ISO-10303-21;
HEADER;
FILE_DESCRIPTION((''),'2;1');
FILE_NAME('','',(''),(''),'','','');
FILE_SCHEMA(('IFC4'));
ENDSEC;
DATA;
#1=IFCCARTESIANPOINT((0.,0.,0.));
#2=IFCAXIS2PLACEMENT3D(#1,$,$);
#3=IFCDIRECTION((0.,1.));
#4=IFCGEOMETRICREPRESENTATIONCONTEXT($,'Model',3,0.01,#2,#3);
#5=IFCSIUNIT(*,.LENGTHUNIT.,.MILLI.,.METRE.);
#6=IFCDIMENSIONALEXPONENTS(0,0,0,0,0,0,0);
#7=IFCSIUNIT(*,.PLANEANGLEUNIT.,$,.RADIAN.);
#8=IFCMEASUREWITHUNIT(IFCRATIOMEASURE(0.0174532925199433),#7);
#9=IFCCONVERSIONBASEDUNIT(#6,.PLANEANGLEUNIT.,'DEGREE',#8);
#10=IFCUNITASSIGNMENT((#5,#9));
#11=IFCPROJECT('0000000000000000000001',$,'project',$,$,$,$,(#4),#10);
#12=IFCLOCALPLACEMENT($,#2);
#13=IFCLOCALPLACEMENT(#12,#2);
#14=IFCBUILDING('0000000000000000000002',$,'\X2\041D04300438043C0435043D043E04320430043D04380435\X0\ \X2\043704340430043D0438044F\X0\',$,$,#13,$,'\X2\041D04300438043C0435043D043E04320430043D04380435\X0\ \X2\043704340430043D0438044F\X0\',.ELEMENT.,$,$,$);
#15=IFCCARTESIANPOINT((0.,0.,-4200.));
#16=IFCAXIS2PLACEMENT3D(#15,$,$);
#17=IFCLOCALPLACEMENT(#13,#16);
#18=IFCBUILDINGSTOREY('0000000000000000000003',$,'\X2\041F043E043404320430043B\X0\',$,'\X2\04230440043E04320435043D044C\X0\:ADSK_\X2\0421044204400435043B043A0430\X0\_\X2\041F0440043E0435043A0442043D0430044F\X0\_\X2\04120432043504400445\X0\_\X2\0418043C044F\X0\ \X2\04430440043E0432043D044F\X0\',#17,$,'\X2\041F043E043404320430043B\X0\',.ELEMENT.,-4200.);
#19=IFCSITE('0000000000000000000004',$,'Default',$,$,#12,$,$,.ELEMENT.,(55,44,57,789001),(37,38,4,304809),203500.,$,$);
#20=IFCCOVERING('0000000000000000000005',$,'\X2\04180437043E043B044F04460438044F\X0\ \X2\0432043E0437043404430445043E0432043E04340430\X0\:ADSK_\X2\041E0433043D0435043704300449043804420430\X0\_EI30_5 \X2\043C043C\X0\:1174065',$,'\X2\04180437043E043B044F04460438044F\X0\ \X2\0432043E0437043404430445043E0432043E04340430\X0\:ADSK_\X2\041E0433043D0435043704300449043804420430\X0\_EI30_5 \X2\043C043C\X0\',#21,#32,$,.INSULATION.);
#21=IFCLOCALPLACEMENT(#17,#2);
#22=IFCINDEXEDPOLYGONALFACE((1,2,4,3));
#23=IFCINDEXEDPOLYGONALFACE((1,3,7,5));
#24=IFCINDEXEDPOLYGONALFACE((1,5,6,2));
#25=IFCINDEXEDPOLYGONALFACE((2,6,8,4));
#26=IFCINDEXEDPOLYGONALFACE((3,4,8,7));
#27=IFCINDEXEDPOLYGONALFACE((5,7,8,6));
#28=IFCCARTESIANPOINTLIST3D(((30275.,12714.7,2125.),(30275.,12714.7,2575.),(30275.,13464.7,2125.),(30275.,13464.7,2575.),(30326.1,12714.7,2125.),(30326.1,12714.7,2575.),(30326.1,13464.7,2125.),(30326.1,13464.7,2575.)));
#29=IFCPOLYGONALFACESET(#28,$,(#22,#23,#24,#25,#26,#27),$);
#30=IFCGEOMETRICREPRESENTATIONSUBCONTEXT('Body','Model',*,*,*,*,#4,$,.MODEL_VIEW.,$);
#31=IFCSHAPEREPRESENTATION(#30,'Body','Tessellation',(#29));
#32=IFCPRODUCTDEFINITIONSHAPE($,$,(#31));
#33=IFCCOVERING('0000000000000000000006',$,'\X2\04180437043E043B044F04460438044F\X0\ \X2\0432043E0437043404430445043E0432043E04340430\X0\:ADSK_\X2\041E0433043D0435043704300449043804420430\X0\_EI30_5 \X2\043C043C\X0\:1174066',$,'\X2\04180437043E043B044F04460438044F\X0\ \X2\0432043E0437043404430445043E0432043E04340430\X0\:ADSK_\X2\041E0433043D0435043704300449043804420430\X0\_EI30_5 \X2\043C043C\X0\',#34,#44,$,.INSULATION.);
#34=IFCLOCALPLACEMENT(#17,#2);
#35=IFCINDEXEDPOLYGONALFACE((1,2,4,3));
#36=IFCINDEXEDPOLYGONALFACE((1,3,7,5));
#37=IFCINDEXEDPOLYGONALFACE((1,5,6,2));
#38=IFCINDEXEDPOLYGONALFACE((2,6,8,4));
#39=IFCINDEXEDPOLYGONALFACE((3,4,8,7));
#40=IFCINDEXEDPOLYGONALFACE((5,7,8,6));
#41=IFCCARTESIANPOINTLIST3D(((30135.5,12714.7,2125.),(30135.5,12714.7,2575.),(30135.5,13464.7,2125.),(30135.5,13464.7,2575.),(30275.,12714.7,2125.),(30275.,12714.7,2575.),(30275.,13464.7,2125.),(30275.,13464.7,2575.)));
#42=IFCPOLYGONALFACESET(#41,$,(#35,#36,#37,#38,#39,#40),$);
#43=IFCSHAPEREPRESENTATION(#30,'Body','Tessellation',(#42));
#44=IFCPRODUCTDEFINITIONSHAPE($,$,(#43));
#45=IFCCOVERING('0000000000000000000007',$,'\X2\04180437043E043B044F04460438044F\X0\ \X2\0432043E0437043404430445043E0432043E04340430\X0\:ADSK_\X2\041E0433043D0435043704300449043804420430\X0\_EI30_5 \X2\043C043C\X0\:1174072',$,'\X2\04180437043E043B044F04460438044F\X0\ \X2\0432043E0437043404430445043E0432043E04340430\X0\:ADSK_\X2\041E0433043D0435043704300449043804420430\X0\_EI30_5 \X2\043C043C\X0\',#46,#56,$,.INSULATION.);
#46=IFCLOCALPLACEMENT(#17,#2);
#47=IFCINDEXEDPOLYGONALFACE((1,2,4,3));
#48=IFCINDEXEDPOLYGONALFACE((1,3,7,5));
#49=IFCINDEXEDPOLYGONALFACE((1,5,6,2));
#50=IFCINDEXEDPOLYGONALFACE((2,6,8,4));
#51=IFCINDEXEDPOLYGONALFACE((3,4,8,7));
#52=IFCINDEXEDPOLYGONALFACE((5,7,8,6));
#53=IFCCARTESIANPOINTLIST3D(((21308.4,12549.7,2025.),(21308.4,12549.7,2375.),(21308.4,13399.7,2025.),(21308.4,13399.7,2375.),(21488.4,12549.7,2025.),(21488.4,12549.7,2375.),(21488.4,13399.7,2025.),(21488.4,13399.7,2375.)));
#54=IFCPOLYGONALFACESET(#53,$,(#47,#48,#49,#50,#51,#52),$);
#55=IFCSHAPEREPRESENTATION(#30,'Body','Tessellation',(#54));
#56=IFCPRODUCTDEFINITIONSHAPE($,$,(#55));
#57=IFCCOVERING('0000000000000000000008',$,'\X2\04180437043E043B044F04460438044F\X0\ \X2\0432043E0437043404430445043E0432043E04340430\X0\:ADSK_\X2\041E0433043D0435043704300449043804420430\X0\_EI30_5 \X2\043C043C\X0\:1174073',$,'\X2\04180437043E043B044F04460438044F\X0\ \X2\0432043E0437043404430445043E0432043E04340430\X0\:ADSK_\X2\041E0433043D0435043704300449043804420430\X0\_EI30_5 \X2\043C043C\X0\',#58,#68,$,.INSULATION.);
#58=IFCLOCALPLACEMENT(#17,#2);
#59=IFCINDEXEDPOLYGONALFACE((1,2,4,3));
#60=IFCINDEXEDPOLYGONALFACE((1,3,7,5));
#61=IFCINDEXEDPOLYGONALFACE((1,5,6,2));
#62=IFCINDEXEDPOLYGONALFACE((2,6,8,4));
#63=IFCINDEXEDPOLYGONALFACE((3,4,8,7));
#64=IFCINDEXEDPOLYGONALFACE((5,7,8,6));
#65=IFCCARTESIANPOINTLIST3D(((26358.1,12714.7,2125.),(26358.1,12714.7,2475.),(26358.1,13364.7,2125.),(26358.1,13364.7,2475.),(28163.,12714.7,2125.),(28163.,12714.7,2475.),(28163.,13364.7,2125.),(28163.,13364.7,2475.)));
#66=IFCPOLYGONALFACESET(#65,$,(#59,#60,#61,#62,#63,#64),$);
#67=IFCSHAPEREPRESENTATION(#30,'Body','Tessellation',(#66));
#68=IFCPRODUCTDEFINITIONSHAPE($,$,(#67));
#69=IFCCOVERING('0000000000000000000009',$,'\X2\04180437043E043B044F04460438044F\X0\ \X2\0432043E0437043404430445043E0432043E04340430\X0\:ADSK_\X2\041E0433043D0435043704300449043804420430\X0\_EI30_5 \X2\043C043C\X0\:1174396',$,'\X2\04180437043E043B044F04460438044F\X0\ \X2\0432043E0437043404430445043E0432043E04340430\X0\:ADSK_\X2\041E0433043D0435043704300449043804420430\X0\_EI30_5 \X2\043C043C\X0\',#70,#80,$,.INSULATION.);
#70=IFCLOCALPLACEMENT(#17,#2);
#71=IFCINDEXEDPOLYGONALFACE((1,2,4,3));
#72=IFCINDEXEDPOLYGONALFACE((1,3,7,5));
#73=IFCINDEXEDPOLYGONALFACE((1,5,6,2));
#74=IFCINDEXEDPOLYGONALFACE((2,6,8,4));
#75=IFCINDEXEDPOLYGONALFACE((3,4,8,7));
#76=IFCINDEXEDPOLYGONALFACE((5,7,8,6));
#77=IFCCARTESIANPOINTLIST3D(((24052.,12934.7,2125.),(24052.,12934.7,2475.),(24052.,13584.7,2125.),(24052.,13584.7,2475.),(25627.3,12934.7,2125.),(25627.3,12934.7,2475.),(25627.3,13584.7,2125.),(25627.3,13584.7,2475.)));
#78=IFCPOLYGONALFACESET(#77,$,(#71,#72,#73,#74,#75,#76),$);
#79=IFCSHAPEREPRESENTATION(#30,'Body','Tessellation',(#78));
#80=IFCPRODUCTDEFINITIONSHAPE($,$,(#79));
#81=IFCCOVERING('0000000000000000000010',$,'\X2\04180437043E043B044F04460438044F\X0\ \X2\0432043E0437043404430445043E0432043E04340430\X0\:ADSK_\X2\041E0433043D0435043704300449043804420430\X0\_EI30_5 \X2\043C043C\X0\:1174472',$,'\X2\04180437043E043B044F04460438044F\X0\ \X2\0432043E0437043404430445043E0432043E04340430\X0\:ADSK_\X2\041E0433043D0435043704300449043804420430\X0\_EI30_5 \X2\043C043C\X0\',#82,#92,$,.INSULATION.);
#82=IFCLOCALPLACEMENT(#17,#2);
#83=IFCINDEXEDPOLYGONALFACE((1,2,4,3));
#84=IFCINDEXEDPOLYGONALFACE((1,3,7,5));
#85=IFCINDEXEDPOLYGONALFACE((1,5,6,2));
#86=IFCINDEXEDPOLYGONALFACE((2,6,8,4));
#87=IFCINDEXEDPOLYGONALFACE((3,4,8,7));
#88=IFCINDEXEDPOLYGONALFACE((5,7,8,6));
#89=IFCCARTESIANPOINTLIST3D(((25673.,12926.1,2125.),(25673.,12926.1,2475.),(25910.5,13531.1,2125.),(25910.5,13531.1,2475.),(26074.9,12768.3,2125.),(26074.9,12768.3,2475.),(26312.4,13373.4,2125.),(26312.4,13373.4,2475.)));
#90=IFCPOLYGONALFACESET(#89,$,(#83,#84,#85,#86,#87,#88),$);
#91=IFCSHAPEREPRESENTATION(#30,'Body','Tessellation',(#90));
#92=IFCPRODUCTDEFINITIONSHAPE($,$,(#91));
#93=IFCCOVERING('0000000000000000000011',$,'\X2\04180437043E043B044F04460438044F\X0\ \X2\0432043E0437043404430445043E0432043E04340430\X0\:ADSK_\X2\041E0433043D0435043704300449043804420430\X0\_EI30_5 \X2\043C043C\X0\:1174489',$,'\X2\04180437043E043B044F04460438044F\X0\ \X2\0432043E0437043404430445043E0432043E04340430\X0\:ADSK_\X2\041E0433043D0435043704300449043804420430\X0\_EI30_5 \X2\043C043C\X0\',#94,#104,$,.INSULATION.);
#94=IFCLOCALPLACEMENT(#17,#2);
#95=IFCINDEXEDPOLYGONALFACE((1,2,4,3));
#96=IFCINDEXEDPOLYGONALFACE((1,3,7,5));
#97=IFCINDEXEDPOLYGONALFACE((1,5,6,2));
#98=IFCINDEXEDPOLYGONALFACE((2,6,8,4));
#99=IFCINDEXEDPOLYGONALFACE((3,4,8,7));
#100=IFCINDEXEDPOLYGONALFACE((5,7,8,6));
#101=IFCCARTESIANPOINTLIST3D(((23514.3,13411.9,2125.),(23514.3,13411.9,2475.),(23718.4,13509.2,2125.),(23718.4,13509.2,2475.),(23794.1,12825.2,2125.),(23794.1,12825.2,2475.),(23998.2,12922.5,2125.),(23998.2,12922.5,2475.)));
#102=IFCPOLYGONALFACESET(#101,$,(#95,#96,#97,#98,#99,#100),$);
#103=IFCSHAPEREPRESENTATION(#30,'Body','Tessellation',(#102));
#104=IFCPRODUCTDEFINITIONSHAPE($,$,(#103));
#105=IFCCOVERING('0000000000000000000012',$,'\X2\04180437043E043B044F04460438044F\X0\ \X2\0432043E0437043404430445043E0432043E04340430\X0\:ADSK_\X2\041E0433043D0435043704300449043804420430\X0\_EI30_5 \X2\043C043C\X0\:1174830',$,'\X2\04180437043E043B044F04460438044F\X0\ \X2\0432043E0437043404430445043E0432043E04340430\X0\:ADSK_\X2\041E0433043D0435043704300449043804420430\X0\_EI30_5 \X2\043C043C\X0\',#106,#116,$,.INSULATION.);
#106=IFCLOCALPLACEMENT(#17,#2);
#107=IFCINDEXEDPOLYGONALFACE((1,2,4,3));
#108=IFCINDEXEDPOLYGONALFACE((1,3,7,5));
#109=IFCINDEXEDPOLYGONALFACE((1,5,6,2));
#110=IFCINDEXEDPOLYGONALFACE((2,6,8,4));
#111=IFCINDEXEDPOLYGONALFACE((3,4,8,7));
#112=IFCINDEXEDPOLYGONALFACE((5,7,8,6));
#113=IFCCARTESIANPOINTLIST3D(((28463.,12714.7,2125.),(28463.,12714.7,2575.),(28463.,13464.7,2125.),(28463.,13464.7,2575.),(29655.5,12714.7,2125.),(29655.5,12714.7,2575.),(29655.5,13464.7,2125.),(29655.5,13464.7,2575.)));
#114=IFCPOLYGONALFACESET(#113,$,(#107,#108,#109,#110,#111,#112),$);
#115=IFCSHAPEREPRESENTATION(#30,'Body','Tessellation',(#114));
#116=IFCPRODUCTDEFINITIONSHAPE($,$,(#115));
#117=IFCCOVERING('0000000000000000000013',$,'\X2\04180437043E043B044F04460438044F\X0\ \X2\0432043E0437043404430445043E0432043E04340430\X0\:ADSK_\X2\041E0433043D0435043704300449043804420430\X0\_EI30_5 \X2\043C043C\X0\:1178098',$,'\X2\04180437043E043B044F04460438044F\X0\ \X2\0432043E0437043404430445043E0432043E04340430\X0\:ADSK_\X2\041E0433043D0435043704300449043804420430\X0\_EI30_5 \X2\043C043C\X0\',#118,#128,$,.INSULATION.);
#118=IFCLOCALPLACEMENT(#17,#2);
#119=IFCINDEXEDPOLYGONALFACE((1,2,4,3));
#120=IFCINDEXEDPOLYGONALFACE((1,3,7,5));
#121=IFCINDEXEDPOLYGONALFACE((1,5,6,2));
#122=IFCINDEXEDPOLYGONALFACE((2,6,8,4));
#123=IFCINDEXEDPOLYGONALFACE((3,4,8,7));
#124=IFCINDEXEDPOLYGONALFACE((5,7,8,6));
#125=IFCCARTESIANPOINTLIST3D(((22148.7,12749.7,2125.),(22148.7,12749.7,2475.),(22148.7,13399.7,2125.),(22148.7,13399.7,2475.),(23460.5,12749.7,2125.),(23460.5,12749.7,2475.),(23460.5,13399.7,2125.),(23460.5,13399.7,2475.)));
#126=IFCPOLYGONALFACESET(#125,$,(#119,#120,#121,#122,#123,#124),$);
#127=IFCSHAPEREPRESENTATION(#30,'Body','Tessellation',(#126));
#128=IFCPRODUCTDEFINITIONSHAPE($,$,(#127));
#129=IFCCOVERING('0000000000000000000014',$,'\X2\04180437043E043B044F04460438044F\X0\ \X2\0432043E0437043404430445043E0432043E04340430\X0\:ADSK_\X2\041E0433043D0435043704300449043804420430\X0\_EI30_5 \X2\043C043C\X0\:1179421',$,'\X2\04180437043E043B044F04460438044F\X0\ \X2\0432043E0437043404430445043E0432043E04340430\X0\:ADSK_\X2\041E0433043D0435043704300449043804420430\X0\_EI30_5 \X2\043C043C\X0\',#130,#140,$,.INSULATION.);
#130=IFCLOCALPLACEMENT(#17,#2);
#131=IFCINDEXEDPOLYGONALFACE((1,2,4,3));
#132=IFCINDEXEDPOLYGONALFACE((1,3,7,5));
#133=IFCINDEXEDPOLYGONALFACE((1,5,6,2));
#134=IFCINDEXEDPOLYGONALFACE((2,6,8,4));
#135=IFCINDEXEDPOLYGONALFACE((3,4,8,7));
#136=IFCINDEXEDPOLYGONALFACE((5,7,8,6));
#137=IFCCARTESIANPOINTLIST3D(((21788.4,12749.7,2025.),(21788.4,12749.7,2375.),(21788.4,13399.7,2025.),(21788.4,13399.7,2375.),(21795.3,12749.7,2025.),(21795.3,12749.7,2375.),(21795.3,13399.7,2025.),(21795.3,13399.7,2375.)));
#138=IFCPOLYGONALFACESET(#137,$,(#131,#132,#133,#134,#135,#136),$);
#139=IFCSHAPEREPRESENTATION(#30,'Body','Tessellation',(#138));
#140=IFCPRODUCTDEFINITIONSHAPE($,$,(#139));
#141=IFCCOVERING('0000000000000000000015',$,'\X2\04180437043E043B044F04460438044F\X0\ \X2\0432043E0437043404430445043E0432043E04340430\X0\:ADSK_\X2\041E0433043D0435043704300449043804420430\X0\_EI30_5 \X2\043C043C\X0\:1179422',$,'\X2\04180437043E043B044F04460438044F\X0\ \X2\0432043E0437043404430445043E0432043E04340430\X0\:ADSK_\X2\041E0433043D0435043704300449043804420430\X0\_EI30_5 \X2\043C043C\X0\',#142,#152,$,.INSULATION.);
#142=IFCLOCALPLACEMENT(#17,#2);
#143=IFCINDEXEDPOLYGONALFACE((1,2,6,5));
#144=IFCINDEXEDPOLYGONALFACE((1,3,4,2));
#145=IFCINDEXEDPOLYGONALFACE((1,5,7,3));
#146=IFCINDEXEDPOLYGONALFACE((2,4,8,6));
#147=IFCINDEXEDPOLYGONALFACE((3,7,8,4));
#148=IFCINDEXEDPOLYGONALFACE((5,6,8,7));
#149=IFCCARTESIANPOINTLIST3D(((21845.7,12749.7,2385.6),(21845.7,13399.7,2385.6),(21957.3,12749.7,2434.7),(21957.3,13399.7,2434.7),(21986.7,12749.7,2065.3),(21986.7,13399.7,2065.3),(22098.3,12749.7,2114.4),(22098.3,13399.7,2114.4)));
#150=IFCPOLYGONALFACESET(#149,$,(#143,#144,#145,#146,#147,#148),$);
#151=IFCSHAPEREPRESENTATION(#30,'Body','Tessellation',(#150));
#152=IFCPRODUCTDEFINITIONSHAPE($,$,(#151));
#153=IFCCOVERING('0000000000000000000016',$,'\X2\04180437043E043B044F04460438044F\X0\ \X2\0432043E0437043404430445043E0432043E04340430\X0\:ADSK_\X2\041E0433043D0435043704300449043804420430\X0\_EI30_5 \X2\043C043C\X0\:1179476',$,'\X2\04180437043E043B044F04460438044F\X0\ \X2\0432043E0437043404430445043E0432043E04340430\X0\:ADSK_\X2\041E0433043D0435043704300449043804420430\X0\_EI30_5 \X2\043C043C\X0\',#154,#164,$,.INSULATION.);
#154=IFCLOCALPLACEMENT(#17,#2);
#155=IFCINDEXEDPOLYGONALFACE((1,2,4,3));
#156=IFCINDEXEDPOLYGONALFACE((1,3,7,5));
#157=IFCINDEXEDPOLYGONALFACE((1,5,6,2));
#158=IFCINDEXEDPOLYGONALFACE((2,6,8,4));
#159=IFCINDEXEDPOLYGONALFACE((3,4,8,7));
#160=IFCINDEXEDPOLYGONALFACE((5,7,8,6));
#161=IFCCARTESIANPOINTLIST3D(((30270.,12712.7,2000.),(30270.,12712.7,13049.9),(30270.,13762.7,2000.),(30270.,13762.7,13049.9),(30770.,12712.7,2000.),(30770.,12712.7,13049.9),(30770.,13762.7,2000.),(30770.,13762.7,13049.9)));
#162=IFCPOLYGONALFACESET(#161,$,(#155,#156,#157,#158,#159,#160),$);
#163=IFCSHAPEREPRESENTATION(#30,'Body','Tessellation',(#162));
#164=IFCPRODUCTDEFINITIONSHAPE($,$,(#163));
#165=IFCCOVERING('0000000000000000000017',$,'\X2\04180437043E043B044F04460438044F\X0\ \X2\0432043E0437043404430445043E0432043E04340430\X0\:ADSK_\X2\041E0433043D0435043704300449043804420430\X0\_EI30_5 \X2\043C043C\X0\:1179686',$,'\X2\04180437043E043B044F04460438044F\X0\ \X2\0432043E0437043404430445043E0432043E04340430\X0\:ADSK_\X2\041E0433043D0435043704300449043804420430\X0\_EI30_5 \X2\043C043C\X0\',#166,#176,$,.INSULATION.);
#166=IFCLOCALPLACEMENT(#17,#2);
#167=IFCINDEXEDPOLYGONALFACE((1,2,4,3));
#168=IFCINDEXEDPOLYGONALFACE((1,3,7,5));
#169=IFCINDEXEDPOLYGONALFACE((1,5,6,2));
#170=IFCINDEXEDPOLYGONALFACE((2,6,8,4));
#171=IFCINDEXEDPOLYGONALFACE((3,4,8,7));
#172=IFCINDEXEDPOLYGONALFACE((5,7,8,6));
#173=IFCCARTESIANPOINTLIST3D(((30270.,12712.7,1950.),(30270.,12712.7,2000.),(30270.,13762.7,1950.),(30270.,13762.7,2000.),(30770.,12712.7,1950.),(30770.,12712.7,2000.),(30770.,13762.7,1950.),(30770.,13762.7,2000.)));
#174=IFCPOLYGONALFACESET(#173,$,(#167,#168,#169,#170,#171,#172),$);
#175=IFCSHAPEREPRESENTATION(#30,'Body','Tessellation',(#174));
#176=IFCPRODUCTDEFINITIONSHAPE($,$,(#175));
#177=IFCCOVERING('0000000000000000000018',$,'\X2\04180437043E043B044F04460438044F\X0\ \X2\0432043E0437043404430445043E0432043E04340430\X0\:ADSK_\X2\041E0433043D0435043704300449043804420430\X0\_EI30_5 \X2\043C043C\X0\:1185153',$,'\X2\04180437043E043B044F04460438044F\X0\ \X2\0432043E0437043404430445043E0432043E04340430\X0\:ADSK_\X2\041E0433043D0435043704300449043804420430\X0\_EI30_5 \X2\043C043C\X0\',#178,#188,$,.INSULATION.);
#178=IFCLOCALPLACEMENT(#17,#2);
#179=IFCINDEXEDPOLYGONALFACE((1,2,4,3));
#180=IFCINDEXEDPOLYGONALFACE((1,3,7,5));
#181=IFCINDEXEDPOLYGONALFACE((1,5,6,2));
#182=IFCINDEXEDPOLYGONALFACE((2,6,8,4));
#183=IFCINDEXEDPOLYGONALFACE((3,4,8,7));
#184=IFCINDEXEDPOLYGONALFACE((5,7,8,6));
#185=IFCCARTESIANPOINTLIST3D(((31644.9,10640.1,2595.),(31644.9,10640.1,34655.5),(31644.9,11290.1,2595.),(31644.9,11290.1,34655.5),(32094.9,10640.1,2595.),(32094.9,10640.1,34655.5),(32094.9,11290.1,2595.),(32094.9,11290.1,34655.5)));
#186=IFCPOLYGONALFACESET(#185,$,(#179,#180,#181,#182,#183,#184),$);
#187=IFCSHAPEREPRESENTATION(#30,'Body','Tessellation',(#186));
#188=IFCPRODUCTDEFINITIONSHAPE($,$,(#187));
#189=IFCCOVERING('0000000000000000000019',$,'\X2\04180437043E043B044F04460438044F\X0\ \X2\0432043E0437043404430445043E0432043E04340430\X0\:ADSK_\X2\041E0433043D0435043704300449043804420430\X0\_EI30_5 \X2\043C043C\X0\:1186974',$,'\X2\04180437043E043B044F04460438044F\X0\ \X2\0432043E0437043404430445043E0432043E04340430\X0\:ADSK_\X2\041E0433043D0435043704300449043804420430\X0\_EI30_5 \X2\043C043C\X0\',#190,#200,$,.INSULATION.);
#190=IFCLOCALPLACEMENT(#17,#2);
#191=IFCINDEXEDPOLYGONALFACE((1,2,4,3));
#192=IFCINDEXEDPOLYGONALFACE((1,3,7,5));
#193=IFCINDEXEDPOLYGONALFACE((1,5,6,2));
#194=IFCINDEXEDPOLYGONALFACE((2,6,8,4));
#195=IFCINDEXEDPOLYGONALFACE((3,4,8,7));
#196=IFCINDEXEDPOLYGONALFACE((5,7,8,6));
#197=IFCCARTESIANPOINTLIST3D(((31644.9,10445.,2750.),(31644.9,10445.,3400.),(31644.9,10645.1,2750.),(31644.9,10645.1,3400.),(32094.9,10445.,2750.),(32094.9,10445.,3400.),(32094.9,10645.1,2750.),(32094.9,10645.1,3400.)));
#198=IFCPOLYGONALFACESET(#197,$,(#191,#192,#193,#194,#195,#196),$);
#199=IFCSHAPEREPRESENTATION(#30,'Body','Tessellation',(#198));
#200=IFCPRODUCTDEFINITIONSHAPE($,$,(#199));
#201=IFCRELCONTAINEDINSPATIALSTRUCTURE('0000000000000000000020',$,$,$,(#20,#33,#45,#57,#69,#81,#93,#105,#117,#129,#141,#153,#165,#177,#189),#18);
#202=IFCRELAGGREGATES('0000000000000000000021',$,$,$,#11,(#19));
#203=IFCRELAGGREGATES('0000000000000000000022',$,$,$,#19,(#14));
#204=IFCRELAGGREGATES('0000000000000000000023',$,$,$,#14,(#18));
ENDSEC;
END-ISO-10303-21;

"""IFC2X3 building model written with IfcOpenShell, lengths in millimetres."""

from ifc_helpers import new_model, entity, si_unit, converted_unit, direction, frame, frame_2d, origin, origin_2d_with_axis, place, context, subcontext, project, spatial, rectangle, extrude, element, save


model = new_model("IFC2X3")

# Units and contexts
model_context = context("Model", 3, precision=0.01, world=origin(), true_north=direction((0.0, 1.0)))
body_context = subcontext(model_context, "Body", "Model", "MODEL_VIEW")
ifc_project = project(units=[si_unit("LENGTHUNIT", "METRE", prefix="MILLI"), converted_unit("PLANEANGLEUNIT", "DEGREE", entity("IfcRatioMeasure", 0.0174532925199433), si_unit("PLANEANGLEUNIT", "RADIAN"), dimensions=[0, 0, 0, 0, 0, 0, 0])], contexts=[model_context])

# Site, building, storey
site_placement = place(None, origin())
site = spatial("IfcSite", under=ifc_project, at=site_placement, Name="Default", CompositionType="ELEMENT", RefLatitude=(55, 44, 57, 789001), RefLongitude=(37, 38, 4, 304809), RefElevation=203500.0)
building_placement = place(site_placement, origin())
building = spatial("IfcBuilding", under=site, at=building_placement, Name="Наименование здания", LongName="Наименование здания", CompositionType="ELEMENT")
storey_placement = place(building_placement, frame((0.0, 0.0, -4200.0)))
storey = spatial("IfcBuildingStorey", under=building, at=storey_placement, Name="Подвал", ObjectType="Уровень:ADSK_Стрелка_Проектная_Вверх_Имя уровня", LongName="Подвал", CompositionType="ELEMENT", Elevation=-4200.0)

# Coverings
covering_1_placement = place(storey_placement, frame((30275.0, 12714.7, 2125.0)))
element("IfcCovering", 1, at=covering_1_placement, inside=storey, Name="Изоляция воздуховода:ADSK_Огнезащита_EI30_5 мм:1174065", ObjectType="Изоляция воздуховода:ADSK_Огнезащита_EI30_5 мм", PredefinedType="INSULATION", context=body_context, shape_type="SweptSolid", body=[
    extrude(rectangle(XDim=750.0, YDim=51.1, at=origin_2d_with_axis()), frame((25.6, 375.0, 0.0), z_axis=(0.0, 0.0, 1.0), x_axis=(0.0, -1.0, 0.0)), (0.0, 0.0, 1.0), 450.0),
])
covering_2_placement = place(storey_placement, frame((30135.5, 12714.7, 2125.0)))
element("IfcCovering", 2, at=covering_2_placement, inside=storey, Name="Изоляция воздуховода:ADSK_Огнезащита_EI30_5 мм:1174066", ObjectType="Изоляция воздуховода:ADSK_Огнезащита_EI30_5 мм", PredefinedType="INSULATION", context=body_context, shape_type="SweptSolid", body=[
    extrude(rectangle(XDim=139.5, YDim=750.0, at=origin_2d_with_axis()), frame((69.7, 375.0, 0.0)), (0.0, 0.0, 1.0), 450.0),
])
covering_3_placement = place(storey_placement, frame((21308.4, 12549.7, 2025.0)))
element("IfcCovering", 3, at=covering_3_placement, inside=storey, Name="Изоляция воздуховода:ADSK_Огнезащита_EI30_5 мм:1174072", ObjectType="Изоляция воздуховода:ADSK_Огнезащита_EI30_5 мм", PredefinedType="INSULATION", context=body_context, shape_type="SweptSolid", body=[
    extrude(rectangle(XDim=180.0, YDim=850.0, at=origin_2d_with_axis()), frame((90.0, 425.0, 0.0)), (0.0, 0.0, 1.0), 350.0),
])
covering_4_placement = place(storey_placement, frame((26358.1, 12714.7, 2125.0)))
element("IfcCovering", 4, at=covering_4_placement, inside=storey, Name="Изоляция воздуховода:ADSK_Огнезащита_EI30_5 мм:1174073", ObjectType="Изоляция воздуховода:ADSK_Огнезащита_EI30_5 мм", PredefinedType="INSULATION", context=body_context, shape_type="SweptSolid", body=[
    extrude(rectangle(XDim=1804.9, YDim=650.0, at=origin_2d_with_axis()), frame((902.5, 325.0, 0.0)), (0.0, 0.0, 1.0), 350.0),
])
covering_5_placement = place(storey_placement, frame((24052.0, 12934.7, 2125.0)))
element("IfcCovering", 5, at=covering_5_placement, inside=storey, Name="Изоляция воздуховода:ADSK_Огнезащита_EI30_5 мм:1174396", ObjectType="Изоляция воздуховода:ADSK_Огнезащита_EI30_5 мм", PredefinedType="INSULATION", context=body_context, shape_type="SweptSolid", body=[
    extrude(rectangle(XDim=1575.3, YDim=650.0, at=origin_2d_with_axis()), frame((787.6, 325.0, 0.0), z_axis=(0.0, 0.0, 1.0), x_axis=(-1.0, 0.0, 0.0)), (0.0, 0.0, 1.0), 350.0),
])
covering_6_placement = place(storey_placement, frame((25673.0, 12768.3, 2125.0)))
element("IfcCovering", 6, at=covering_6_placement, inside=storey, Name="Изоляция воздуховода:ADSK_Огнезащита_EI30_5 мм:1174472", ObjectType="Изоляция воздуховода:ADSK_Огнезащита_EI30_5 мм", PredefinedType="INSULATION", context=body_context, shape_type="SweptSolid", body=[
    extrude(rectangle(XDim=431.8, YDim=650.0, at=origin_2d_with_axis()), frame((319.7, 381.4, 0.0), z_axis=(0.0, 0.0, 1.0), x_axis=(-0.930852, 0.365397, 0.0)), (0.0, 0.0, 1.0), 350.0),
])
covering_7_placement = place(storey_placement, frame((23514.3, 12825.2, 2125.0)))
element("IfcCovering", 7, at=covering_7_placement, inside=storey, Name="Изоляция воздуховода:ADSK_Огнезащита_EI30_5 мм:1174489", ObjectType="Изоляция воздуховода:ADSK_Огнезащита_EI30_5 мм", PredefinedType="INSULATION", context=body_context, shape_type="SweptSolid", body=[
    extrude(rectangle(XDim=226.1, YDim=650.0, at=origin_2d_with_axis()), frame((241.9, 342.0, 0.0), z_axis=(0.0, 0.0, 1.0), x_axis=(0.902595, 0.430491, 0.0)), (0.0, 0.0, 1.0), 350.0),
])
covering_8_placement = place(storey_placement, frame((28463.0, 12714.7, 2125.0)))
element("IfcCovering", 8, at=covering_8_placement, inside=storey, Name="Изоляция воздуховода:ADSK_Огнезащита_EI30_5 мм:1174830", ObjectType="Изоляция воздуховода:ADSK_Огнезащита_EI30_5 мм", PredefinedType="INSULATION", context=body_context, shape_type="SweptSolid", body=[
    extrude(rectangle(XDim=1192.5, YDim=750.0, at=origin_2d_with_axis()), frame((596.3, 375.0, 0.0), z_axis=(0.0, 0.0, 1.0), x_axis=(-1.0, 0.0, 0.0)), (0.0, 0.0, 1.0), 450.0),
])
covering_9_placement = place(storey_placement, frame((22148.7, 12749.7, 2125.0)))
element("IfcCovering", 9, at=covering_9_placement, inside=storey, Name="Изоляция воздуховода:ADSK_Огнезащита_EI30_5 мм:1178098", ObjectType="Изоляция воздуховода:ADSK_Огнезащита_EI30_5 мм", PredefinedType="INSULATION", context=body_context, shape_type="SweptSolid", body=[
    extrude(rectangle(XDim=1311.8, YDim=650.0, at=origin_2d_with_axis()), frame((655.9, 325.0, 0.0)), (0.0, 0.0, 1.0), 350.0),
])
covering_10_placement = place(storey_placement, frame((21788.4, 12749.7, 2025.0)))
element("IfcCovering", 10, at=covering_10_placement, inside=storey, Name="Изоляция воздуховода:ADSK_Огнезащита_EI30_5 мм:1179421", ObjectType="Изоляция воздуховода:ADSK_Огнезащита_EI30_5 мм", PredefinedType="INSULATION", context=body_context, shape_type="SweptSolid", body=[
    extrude(rectangle(XDim=6.9, YDim=650.0, at=origin_2d_with_axis()), frame((3.4, 325.0, 0.0)), (0.0, 0.0, 1.0), 350.0),
])
covering_11_placement = place(storey_placement, frame((21845.7, 12749.7, 2065.3)))
element("IfcCovering", 11, at=covering_11_placement, inside=storey, Name="Изоляция воздуховода:ADSK_Огнезащита_EI30_5 мм:1179422", ObjectType="Изоляция воздуховода:ADSK_Огнезащита_EI30_5 мм", PredefinedType="INSULATION", context=body_context, shape_type="SweptSolid", body=[
    extrude(rectangle(XDim=350.0, YDim=122.0, at=frame_2d((0.0, 0.0), x_axis=(0.0, 1.0))), frame((126.3, 0.0, 184.7), z_axis=(0.0, 1.0, 0.0), x_axis=(-0.915232, 0.0, -0.402928)), (0.0, 0.0, 1.0), 650.0),
])
covering_12_placement = place(storey_placement, frame((30270.0, 12712.7, 2000.0)))
element("IfcCovering", 12, at=covering_12_placement, inside=storey, Name="Изоляция воздуховода:ADSK_Огнезащита_EI30_5 мм:1179476", ObjectType="Изоляция воздуховода:ADSK_Огнезащита_EI30_5 мм", PredefinedType="INSULATION", context=body_context, shape_type="SweptSolid", body=[
    extrude(rectangle(XDim=1050.0, YDim=500.0, at=origin_2d_with_axis()), frame((250.0, 525.0, 0.0), z_axis=(0.0, 0.0, 1.0), x_axis=(0.0, -1.0, 0.0)), (0.0, 0.0, 1.0), 11049.9),
])
covering_13_placement = place(storey_placement, frame((30270.0, 12712.7, 1950.0)))
element("IfcCovering", 13, at=covering_13_placement, inside=storey, Name="Изоляция воздуховода:ADSK_Огнезащита_EI30_5 мм:1179686", ObjectType="Изоляция воздуховода:ADSK_Огнезащита_EI30_5 мм", PredefinedType="INSULATION", context=body_context, shape_type="SweptSolid", body=[
    extrude(rectangle(XDim=500.0, YDim=1050.0, at=origin_2d_with_axis()), frame((250.0, 525.0, 0.0), z_axis=(0.0, 0.0, 1.0), x_axis=(-1.0, 0.0, 0.0)), (0.0, 0.0, 1.0), 50.0),
])
covering_14_placement = place(storey_placement, frame((31644.9, 10640.1, 2595.0)))
element("IfcCovering", 14, at=covering_14_placement, inside=storey, Name="Изоляция воздуховода:ADSK_Огнезащита_EI30_5 мм:1185153", ObjectType="Изоляция воздуховода:ADSK_Огнезащита_EI30_5 мм", PredefinedType="INSULATION", context=body_context, shape_type="SweptSolid", body=[
    extrude(rectangle(XDim=650.0, YDim=450.0, at=origin_2d_with_axis()), frame((225.0, 325.0, 0.0), z_axis=(0.0, 0.0, 1.0), x_axis=(0.0, 1.0, 0.0)), (0.0, 0.0, 1.0), 32060.5),
])
covering_15_placement = place(storey_placement, frame((31644.9, 10445.0, 2750.0)))
element("IfcCovering", 15, at=covering_15_placement, inside=storey, Name="Изоляция воздуховода:ADSK_Огнезащита_EI30_5 мм:1186974", ObjectType="Изоляция воздуховода:ADSK_Огнезащита_EI30_5 мм", PredefinedType="INSULATION", context=body_context, shape_type="SweptSolid", body=[
    extrude(rectangle(XDim=200.1, YDim=450.0, at=origin_2d_with_axis()), frame((225.0, 100.0, 0.0), z_axis=(0.0, 0.0, 1.0), x_axis=(0.0, 1.0, 0.0)), (0.0, 0.0, 1.0), 650.0),
])

save(model, "model.ifc")
